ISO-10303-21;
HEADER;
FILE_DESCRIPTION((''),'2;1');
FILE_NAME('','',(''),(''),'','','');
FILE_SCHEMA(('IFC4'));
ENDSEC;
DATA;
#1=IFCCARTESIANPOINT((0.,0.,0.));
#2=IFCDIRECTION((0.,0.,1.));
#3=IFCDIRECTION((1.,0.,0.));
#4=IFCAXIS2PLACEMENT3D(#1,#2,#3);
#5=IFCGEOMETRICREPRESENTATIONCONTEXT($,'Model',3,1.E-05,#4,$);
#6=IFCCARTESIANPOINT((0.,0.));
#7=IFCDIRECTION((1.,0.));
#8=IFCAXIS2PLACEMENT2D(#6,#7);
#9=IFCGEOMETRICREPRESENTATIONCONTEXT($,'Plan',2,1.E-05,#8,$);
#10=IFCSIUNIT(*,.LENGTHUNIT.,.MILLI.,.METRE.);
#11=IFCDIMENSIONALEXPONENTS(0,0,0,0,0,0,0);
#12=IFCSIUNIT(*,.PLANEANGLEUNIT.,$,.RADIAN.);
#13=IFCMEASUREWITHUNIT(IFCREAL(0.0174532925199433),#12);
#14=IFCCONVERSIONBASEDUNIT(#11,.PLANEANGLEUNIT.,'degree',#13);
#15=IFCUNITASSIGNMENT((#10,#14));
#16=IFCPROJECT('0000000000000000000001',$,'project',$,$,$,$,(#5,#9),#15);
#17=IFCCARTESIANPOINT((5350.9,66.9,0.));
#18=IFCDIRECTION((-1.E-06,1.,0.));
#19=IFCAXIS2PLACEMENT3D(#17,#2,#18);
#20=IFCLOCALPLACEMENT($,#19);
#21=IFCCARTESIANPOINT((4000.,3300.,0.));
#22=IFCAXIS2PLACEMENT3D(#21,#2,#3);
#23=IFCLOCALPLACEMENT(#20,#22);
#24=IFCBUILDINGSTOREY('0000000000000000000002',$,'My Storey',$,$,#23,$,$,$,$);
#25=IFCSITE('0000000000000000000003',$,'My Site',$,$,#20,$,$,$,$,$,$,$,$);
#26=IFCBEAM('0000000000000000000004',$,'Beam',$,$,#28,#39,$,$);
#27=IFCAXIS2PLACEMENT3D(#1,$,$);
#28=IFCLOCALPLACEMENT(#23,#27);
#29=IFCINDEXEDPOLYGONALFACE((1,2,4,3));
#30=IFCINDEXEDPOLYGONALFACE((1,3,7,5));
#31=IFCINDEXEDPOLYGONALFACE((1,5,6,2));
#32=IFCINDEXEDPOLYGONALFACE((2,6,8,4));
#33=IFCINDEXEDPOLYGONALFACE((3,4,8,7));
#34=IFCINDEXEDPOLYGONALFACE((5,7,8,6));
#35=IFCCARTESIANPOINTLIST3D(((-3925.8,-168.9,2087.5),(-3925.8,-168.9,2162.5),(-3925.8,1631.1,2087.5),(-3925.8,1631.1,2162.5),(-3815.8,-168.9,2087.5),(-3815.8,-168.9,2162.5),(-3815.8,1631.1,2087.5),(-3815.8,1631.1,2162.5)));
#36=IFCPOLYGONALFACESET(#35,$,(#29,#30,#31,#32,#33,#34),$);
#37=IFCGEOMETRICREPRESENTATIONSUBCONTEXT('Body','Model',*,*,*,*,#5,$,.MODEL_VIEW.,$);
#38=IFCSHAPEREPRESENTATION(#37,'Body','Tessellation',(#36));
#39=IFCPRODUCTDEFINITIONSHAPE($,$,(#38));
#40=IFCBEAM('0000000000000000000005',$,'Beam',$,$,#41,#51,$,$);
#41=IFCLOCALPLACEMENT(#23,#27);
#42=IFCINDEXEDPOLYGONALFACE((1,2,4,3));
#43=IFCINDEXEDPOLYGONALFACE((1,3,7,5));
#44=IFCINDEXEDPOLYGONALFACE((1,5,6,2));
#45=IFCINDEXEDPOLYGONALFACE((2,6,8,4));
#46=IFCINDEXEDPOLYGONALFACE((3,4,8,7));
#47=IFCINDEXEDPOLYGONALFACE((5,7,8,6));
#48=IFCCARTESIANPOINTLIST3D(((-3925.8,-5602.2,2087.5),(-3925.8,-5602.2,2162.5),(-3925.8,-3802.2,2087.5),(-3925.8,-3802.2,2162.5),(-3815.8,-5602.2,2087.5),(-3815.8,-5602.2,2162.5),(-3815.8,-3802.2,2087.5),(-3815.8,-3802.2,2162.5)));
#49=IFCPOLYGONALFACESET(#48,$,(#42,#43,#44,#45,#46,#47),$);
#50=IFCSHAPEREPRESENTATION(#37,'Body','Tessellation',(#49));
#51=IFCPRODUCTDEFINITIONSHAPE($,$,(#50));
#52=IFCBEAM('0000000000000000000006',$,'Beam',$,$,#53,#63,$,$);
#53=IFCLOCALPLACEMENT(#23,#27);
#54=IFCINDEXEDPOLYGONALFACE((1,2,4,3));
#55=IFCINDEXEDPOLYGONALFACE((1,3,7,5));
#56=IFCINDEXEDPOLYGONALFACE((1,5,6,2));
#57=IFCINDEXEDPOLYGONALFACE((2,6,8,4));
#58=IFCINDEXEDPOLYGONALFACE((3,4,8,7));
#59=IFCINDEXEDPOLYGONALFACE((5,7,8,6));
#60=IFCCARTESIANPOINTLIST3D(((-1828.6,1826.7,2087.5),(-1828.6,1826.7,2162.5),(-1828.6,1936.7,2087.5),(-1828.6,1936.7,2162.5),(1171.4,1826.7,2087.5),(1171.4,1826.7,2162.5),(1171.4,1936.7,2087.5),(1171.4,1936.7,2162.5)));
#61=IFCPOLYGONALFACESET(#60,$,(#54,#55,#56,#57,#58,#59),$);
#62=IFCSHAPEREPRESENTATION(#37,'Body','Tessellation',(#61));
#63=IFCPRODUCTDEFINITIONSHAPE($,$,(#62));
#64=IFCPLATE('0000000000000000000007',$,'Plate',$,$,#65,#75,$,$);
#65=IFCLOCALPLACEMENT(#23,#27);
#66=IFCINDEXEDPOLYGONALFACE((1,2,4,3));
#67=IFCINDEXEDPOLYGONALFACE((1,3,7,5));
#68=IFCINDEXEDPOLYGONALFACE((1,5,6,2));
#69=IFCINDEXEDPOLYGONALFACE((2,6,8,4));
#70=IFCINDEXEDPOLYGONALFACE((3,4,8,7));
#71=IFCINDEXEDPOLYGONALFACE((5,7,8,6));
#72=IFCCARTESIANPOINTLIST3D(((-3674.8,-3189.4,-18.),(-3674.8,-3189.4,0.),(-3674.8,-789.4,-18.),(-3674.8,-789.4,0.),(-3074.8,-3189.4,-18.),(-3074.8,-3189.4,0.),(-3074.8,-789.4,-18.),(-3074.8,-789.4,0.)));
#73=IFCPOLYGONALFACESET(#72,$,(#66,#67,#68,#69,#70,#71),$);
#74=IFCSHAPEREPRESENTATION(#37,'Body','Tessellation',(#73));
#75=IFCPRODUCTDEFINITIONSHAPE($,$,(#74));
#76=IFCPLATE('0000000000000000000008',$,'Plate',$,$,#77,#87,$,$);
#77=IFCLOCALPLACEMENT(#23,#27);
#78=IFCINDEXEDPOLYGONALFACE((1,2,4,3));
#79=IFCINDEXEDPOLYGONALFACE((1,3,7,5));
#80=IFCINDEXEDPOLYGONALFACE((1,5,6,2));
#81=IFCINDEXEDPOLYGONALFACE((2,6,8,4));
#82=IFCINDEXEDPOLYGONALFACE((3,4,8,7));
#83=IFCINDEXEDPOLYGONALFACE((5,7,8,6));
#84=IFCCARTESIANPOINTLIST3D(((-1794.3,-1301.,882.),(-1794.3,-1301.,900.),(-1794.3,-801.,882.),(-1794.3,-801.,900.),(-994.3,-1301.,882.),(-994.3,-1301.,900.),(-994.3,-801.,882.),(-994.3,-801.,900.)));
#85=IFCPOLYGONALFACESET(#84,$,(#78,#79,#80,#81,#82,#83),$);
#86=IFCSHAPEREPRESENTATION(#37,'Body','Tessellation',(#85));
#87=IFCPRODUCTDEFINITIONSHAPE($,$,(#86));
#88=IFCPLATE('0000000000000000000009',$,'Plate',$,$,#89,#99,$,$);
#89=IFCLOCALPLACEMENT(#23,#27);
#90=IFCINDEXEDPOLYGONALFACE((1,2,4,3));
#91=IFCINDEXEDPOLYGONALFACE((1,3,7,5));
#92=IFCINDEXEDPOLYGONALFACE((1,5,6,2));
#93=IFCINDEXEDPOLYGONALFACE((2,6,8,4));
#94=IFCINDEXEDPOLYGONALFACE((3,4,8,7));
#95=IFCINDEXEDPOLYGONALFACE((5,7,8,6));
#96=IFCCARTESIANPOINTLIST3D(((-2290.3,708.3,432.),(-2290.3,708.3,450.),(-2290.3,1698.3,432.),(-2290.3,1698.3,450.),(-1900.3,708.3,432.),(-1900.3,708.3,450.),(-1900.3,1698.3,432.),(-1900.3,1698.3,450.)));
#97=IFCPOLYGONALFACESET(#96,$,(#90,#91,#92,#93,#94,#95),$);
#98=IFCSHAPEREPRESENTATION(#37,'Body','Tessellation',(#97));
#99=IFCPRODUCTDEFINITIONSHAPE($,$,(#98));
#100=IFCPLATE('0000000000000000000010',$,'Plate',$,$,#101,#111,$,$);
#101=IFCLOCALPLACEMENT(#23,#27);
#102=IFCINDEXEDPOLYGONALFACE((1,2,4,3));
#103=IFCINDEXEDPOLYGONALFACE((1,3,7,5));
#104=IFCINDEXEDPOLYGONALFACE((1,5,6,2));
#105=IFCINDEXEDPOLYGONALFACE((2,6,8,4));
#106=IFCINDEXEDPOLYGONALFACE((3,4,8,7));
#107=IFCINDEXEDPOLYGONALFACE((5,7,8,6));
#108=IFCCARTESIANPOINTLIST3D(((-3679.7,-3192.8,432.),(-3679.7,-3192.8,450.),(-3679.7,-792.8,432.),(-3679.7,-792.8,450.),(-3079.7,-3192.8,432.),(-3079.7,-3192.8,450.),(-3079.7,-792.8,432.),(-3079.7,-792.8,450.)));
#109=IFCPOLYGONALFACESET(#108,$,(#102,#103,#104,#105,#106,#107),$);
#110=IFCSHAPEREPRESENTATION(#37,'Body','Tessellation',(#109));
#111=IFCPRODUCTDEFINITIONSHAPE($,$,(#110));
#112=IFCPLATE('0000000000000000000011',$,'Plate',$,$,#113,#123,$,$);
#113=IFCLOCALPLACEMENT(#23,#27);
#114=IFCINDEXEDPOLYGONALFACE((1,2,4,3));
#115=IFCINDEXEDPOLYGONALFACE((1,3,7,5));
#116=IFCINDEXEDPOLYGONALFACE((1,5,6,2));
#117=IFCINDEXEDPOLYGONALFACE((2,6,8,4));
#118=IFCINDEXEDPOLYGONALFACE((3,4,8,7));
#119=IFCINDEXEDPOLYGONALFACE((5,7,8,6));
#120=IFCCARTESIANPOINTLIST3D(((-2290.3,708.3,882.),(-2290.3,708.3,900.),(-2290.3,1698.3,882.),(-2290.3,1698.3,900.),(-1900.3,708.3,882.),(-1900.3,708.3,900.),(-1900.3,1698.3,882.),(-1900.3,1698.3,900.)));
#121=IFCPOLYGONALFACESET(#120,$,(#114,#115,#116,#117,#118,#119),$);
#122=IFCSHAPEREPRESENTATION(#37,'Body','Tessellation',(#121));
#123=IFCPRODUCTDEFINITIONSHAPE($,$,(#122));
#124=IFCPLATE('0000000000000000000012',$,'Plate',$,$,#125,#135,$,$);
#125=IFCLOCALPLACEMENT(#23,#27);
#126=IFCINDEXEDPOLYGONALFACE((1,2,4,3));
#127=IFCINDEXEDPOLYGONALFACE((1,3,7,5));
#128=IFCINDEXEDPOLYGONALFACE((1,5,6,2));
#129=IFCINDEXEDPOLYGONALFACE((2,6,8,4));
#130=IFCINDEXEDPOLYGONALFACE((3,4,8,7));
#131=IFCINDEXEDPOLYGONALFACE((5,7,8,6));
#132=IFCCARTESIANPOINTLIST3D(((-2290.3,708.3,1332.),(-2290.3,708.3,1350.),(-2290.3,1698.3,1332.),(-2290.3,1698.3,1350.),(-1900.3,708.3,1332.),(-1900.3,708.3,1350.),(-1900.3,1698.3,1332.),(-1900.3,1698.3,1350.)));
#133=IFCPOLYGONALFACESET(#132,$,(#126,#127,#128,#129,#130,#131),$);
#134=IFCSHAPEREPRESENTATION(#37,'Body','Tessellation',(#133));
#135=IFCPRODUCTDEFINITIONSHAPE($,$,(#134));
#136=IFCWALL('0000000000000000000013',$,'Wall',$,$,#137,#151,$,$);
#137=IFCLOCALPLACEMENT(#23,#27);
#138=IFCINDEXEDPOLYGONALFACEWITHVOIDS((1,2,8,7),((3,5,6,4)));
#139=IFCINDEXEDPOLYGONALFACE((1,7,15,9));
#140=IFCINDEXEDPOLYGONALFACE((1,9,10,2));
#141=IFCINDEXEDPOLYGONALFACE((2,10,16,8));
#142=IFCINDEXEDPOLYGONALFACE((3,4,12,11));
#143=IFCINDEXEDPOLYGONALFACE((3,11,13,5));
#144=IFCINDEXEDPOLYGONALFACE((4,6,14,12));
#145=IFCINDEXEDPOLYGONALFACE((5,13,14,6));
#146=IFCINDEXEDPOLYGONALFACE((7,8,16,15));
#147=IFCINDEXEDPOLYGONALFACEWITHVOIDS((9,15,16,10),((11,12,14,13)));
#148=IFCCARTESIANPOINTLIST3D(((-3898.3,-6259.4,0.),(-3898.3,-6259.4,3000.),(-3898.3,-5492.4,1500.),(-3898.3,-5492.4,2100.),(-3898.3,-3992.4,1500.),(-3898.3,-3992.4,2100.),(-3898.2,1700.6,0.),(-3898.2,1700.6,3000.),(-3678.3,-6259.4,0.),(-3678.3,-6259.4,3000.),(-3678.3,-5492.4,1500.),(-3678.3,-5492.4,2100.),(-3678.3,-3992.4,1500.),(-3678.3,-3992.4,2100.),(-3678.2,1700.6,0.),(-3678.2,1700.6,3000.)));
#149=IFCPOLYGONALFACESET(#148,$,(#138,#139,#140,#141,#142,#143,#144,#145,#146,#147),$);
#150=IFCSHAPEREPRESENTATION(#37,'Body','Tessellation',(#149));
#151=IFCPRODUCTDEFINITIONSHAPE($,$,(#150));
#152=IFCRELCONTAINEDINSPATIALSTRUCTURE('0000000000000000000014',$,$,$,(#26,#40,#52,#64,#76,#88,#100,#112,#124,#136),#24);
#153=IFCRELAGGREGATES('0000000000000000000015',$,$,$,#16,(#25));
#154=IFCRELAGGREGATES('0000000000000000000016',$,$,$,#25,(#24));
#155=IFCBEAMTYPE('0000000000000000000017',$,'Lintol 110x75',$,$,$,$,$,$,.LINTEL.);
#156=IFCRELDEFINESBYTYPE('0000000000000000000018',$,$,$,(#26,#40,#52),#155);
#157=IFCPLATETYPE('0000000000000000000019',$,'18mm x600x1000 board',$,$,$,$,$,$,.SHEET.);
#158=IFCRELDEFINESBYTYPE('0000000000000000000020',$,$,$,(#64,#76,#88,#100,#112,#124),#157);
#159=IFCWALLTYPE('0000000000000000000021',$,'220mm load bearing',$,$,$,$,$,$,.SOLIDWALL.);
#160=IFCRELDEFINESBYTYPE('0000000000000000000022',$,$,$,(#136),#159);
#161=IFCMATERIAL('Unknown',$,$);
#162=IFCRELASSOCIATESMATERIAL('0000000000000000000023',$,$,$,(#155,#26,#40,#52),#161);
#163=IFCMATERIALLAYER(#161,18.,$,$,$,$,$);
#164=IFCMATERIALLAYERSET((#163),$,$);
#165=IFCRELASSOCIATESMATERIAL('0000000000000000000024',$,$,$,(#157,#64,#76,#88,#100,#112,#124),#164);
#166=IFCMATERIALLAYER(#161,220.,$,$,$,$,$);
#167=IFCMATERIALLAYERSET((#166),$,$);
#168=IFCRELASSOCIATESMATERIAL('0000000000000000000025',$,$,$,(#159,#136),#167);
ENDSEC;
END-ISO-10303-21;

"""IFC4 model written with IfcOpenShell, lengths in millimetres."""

from ifc_helpers import new_model, entity, si_unit, converted_unit, frame, origin_with_axes, origin_2d_with_axis, place, context, subcontext, project, spatial, line, indexed_curve, rectangle, outline, extrude, source, transform, mapped, material, layer, layer_set, layer_usage, material_profile, profile_set, profile_usage, type_object, element, save


model = new_model("IFC4")

# Units and contexts
model_context = context("Model", 3, precision=1e-05, world=origin_with_axes())
plan_context = context("Plan", 2, precision=1e-05, world=origin_2d_with_axis())
body_context = subcontext(model_context, "Body", "Model", "MODEL_VIEW")
ifc_project = project(units=[si_unit("LENGTHUNIT", "METRE", prefix="MILLI"), converted_unit("PLANEANGLEUNIT", "degree", entity("IfcReal", 0.0174532925199433), si_unit("PLANEANGLEUNIT", "RADIAN"), dimensions=[0, 0, 0, 0, 0, 0, 0])], contexts=[model_context, plan_context])

# Site, storey
site_placement = place(None, frame((5350.9, 66.9, 0.0), z_axis=(0.0, 0.0, 1.0), x_axis=(-0.000001, 1.0, 0.0)))
site = spatial("IfcSite", under=ifc_project, at=site_placement, Name="My Site")
storey_placement = place(site_placement, frame((4000.0, 3300.0, 0.0), z_axis=(0.0, 0.0, 1.0), x_axis=(1.0, 0.0, 0.0)))
storey = spatial("IfcBuildingStorey", under=site, at=storey_placement, Name="My Storey")

# Beams
ifc_material = material(Name="Unknown")
ifc_material_profile = material_profile(ifc_material, rectangle(XDim=110.0, YDim=75.0))
ifc_profile_set = profile_set([ifc_material_profile])
ifc_profile_usage_1 = profile_usage(ifc_profile_set, cardinal=5)
beam_type = type_object("IfcBeamType", Name="Lintol 110x75", PredefinedType="LINTEL", material=ifc_profile_set)
beam_1_placement = place(storey_placement, frame((-3870.8, 1631.1, 2125.0), z_axis=(-0.000001, -1.0, 0.0), x_axis=(1.0, -0.000001, 0.0)))
element("IfcBeam", 1, at=beam_1_placement, inside=storey, type_object=beam_type, material=ifc_profile_usage_1, Name="Beam", context=body_context, shape_type="SweptSolid", body=[
    extrude(rectangle(XDim=110.0, YDim=75.0), origin_with_axes(), (0.0, 0.0, 1.0), 1800.0),
])
ifc_profile_usage_2 = profile_usage(ifc_profile_set, cardinal=5)
beam_2_placement = place(storey_placement, frame((-3870.8, -3802.2, 2125.0), z_axis=(-0.000001, -1.0, 0.0), x_axis=(1.0, -0.000001, 0.0)))
element("IfcBeam", 2, at=beam_2_placement, inside=storey, type_object=beam_type, material=ifc_profile_usage_2, Name="Beam", context=body_context, shape_type="SweptSolid", body=[
    extrude(rectangle(XDim=110.0, YDim=75.0), origin_with_axes(), (0.0, 0.0, 1.0), 1800.0),
])
ifc_profile_usage_3 = profile_usage(ifc_profile_set, cardinal=5)
beam_3_placement = place(storey_placement, frame((-1828.6, 1881.7, 2125.0), z_axis=(1.0, -0.000001, 0.0), x_axis=(0.000001, 1.0, 0.0)))
element("IfcBeam", 3, at=beam_3_placement, inside=storey, type_object=beam_type, material=ifc_profile_usage_3, Name="Beam", context=body_context, shape_type="SweptSolid", body=[
    extrude(rectangle(XDim=110.0, YDim=75.0), origin_with_axes(), (0.0, 0.0, 1.0), 3000.0),
])

# Plates
ifc_layer_1 = layer(ifc_material, 18.0)
ifc_layer_set_1 = layer_set([ifc_layer_1])
ifc_layer_usage_1 = layer_usage(ifc_layer_set_1, "AXIS3", "POSITIVE", 0.0)
plate_type = type_object("IfcPlateType", Name="18mm x600x1000 board", PredefinedType="SHEET", material=ifc_layer_set_1)
plate_1_placement = place(storey_placement, frame((-3674.8, -789.4, -18.0), z_axis=(0.0, 0.0, 1.0), x_axis=(0.0, -1.0, 0.0)))
element("IfcPlate", 4, at=plate_1_placement, inside=storey, type_object=plate_type, material=ifc_layer_usage_1, Name="Plate", context=body_context, shape_type="SweptSolid", body=[
    extrude(outline(indexed_curve([(0.0, 600.0), (0.0, 0.0), (2400.0, 0.0), (2400.0, 600.0)], segments=[line(4, 1), line(1, 2), line(2, 3), line(3, 4)], self_intersect=False)), None, (0.0, 0.0, 1.0), 18.0),
])
ifc_layer_usage_2 = layer_usage(ifc_layer_set_1, "AXIS3", "POSITIVE", 0.0)
plate_2_placement = place(storey_placement, frame((-994.3, -801.0, 882.0), z_axis=(0.0, 0.0, 1.0), x_axis=(-1.0, 0.0, 0.0)))
element("IfcPlate", 5, at=plate_2_placement, inside=storey, type_object=plate_type, material=ifc_layer_usage_2, Name="Plate", context=body_context, shape_type="SweptSolid", body=[
    extrude(outline(indexed_curve([(0.0, 500.0), (0.0, 0.0), (800.0, 0.0), (800.0, 500.0)], segments=[line(3, 2), line(2, 1), line(1, 4), line(4, 3)], self_intersect=False)), None, (0.0, 0.0, 1.0), 18.0),
])
ifc_layer_usage_3 = layer_usage(ifc_layer_set_1, "AXIS3", "POSITIVE", 0.0)
plate_3_placement = place(storey_placement, frame((-2290.3, 1698.3, 432.0), z_axis=(0.0, 0.0, 1.0), x_axis=(0.0, -1.0, 0.0)))
element("IfcPlate", 6, at=plate_3_placement, inside=storey, type_object=plate_type, material=ifc_layer_usage_3, Name="Plate", context=body_context, shape_type="SweptSolid", body=[
    extrude(outline(indexed_curve([(0.0, 390.0), (0.0, 0.0), (990.0, 0.0), (990.0, 390.0)], segments=[line(4, 1), line(1, 2), line(2, 3), line(3, 4)], self_intersect=False)), None, (0.0, 0.0, 1.0), 18.0),
])
ifc_layer_usage_4 = layer_usage(ifc_layer_set_1, "AXIS3", "POSITIVE", 0.0)
plate_4_placement = place(storey_placement, frame((-3679.7, -792.8, 432.0), z_axis=(0.0, 0.0, 1.0), x_axis=(0.0, -1.0, 0.0)))
element("IfcPlate", 7, at=plate_4_placement, inside=storey, type_object=plate_type, material=ifc_layer_usage_4, Name="Plate", context=body_context, shape_type="SweptSolid", body=[
    extrude(outline(indexed_curve([(0.0, 600.0), (0.0, 0.0), (2400.0, 0.0), (2400.0, 600.0)], segments=[line(4, 1), line(1, 2), line(2, 3), line(3, 4)], self_intersect=False)), None, (0.0, 0.0, 1.0), 18.0),
])
ifc_layer_usage_5 = layer_usage(ifc_layer_set_1, "AXIS3", "POSITIVE", 0.0)
plate_5_placement = place(storey_placement, frame((-2290.3, 1698.3, 882.0), z_axis=(0.0, 0.0, 1.0), x_axis=(0.0, -1.0, 0.0)))
element("IfcPlate", 8, at=plate_5_placement, inside=storey, type_object=plate_type, material=ifc_layer_usage_5, Name="Plate", context=body_context, shape_type="SweptSolid", body=[
    extrude(outline(indexed_curve([(0.0, 390.0), (0.0, 0.0), (990.0, 0.0), (990.0, 390.0)], segments=[line(4, 1), line(1, 2), line(2, 3), line(3, 4)], self_intersect=False)), None, (0.0, 0.0, 1.0), 18.0),
])
ifc_layer_usage_6 = layer_usage(ifc_layer_set_1, "AXIS3", "POSITIVE", 0.0)
plate_6_placement = place(storey_placement, frame((-2290.3, 1698.3, 1332.0), z_axis=(0.0, 0.0, 1.0), x_axis=(0.0, -1.0, 0.0)))
element("IfcPlate", 9, at=plate_6_placement, inside=storey, type_object=plate_type, material=ifc_layer_usage_6, Name="Plate", context=body_context, shape_type="SweptSolid", body=[
    extrude(outline(indexed_curve([(0.0, 390.0), (0.0, 0.0), (990.0, 0.0), (990.0, 390.0)], segments=[line(4, 1), line(1, 2), line(2, 3), line(3, 4)], self_intersect=False)), None, (0.0, 0.0, 1.0), 18.0),
])

# Wall, opening
ifc_layer_2 = layer(ifc_material, 220.0)
ifc_layer_set_2 = layer_set([ifc_layer_2])
ifc_layer_usage_7 = layer_usage(ifc_layer_set_2, "AXIS2", "POSITIVE", 0.0)
wall_type_1 = type_object("IfcWallType", Name="220mm load bearing", PredefinedType="SOLIDWALL", material=ifc_layer_set_2)
wall_1_placement = place(storey_placement, frame((-3898.2, 1700.6, 0.0), z_axis=(0.0, 0.0, 1.0), x_axis=(-0.000001, -1.0, 0.0)))
wall_1 = element("IfcWall", 10, at=wall_1_placement, inside=storey, type_object=wall_type_1, material=ifc_layer_usage_7, Name="Wall", context=body_context, shape_type="SweptSolid", body=[
    extrude(outline(indexed_curve([(0.0, 0.0), (0.0, 220.0), (7960.0, 220.0), (7960.0, 0.0), (0.0, 0.0)], self_intersect=False)), origin_with_axes(), (0.0, 0.0, 1.0), 3000.0),
])
shared_shape_1 = source(origin_with_axes(), body_context, "Body", "SweptSolid", [
    extrude(outline(indexed_curve([(0.0, 0.0), (1500.0, 0.0), (1500.0, 600.0), (0.0, 600.0)], segments=[line(1, 2, 3, 4, 1)])), frame((0.0, -100.0, 0.0), z_axis=(0.0, -1.0, 0.0), x_axis=(1.0, 0.0, 0.0)), (0.0, 0.0, -1.0), 420.0),
])
opening_1_placement = place(wall_1_placement, frame((5693.0, 72.5, 1500.0), z_axis=(0.0, 0.0, 1.0), x_axis=(1.0, 0.0, 0.0)))
element("IfcOpeningElement", 11, at=opening_1_placement, cuts=wall_1, PredefinedType="OPENING", context=body_context, shape_type="MappedRepresentation", body=[
    mapped(shared_shape_1, transform((0.0, 0.0, 0.0), x_axis=(1.0, 0.0, 0.0), y_axis=(0.0, 1.0, 0.0), z_axis=(0.0, 0.0, 1.0), scale=1.0)),
])

save(model, "model.ifc")
